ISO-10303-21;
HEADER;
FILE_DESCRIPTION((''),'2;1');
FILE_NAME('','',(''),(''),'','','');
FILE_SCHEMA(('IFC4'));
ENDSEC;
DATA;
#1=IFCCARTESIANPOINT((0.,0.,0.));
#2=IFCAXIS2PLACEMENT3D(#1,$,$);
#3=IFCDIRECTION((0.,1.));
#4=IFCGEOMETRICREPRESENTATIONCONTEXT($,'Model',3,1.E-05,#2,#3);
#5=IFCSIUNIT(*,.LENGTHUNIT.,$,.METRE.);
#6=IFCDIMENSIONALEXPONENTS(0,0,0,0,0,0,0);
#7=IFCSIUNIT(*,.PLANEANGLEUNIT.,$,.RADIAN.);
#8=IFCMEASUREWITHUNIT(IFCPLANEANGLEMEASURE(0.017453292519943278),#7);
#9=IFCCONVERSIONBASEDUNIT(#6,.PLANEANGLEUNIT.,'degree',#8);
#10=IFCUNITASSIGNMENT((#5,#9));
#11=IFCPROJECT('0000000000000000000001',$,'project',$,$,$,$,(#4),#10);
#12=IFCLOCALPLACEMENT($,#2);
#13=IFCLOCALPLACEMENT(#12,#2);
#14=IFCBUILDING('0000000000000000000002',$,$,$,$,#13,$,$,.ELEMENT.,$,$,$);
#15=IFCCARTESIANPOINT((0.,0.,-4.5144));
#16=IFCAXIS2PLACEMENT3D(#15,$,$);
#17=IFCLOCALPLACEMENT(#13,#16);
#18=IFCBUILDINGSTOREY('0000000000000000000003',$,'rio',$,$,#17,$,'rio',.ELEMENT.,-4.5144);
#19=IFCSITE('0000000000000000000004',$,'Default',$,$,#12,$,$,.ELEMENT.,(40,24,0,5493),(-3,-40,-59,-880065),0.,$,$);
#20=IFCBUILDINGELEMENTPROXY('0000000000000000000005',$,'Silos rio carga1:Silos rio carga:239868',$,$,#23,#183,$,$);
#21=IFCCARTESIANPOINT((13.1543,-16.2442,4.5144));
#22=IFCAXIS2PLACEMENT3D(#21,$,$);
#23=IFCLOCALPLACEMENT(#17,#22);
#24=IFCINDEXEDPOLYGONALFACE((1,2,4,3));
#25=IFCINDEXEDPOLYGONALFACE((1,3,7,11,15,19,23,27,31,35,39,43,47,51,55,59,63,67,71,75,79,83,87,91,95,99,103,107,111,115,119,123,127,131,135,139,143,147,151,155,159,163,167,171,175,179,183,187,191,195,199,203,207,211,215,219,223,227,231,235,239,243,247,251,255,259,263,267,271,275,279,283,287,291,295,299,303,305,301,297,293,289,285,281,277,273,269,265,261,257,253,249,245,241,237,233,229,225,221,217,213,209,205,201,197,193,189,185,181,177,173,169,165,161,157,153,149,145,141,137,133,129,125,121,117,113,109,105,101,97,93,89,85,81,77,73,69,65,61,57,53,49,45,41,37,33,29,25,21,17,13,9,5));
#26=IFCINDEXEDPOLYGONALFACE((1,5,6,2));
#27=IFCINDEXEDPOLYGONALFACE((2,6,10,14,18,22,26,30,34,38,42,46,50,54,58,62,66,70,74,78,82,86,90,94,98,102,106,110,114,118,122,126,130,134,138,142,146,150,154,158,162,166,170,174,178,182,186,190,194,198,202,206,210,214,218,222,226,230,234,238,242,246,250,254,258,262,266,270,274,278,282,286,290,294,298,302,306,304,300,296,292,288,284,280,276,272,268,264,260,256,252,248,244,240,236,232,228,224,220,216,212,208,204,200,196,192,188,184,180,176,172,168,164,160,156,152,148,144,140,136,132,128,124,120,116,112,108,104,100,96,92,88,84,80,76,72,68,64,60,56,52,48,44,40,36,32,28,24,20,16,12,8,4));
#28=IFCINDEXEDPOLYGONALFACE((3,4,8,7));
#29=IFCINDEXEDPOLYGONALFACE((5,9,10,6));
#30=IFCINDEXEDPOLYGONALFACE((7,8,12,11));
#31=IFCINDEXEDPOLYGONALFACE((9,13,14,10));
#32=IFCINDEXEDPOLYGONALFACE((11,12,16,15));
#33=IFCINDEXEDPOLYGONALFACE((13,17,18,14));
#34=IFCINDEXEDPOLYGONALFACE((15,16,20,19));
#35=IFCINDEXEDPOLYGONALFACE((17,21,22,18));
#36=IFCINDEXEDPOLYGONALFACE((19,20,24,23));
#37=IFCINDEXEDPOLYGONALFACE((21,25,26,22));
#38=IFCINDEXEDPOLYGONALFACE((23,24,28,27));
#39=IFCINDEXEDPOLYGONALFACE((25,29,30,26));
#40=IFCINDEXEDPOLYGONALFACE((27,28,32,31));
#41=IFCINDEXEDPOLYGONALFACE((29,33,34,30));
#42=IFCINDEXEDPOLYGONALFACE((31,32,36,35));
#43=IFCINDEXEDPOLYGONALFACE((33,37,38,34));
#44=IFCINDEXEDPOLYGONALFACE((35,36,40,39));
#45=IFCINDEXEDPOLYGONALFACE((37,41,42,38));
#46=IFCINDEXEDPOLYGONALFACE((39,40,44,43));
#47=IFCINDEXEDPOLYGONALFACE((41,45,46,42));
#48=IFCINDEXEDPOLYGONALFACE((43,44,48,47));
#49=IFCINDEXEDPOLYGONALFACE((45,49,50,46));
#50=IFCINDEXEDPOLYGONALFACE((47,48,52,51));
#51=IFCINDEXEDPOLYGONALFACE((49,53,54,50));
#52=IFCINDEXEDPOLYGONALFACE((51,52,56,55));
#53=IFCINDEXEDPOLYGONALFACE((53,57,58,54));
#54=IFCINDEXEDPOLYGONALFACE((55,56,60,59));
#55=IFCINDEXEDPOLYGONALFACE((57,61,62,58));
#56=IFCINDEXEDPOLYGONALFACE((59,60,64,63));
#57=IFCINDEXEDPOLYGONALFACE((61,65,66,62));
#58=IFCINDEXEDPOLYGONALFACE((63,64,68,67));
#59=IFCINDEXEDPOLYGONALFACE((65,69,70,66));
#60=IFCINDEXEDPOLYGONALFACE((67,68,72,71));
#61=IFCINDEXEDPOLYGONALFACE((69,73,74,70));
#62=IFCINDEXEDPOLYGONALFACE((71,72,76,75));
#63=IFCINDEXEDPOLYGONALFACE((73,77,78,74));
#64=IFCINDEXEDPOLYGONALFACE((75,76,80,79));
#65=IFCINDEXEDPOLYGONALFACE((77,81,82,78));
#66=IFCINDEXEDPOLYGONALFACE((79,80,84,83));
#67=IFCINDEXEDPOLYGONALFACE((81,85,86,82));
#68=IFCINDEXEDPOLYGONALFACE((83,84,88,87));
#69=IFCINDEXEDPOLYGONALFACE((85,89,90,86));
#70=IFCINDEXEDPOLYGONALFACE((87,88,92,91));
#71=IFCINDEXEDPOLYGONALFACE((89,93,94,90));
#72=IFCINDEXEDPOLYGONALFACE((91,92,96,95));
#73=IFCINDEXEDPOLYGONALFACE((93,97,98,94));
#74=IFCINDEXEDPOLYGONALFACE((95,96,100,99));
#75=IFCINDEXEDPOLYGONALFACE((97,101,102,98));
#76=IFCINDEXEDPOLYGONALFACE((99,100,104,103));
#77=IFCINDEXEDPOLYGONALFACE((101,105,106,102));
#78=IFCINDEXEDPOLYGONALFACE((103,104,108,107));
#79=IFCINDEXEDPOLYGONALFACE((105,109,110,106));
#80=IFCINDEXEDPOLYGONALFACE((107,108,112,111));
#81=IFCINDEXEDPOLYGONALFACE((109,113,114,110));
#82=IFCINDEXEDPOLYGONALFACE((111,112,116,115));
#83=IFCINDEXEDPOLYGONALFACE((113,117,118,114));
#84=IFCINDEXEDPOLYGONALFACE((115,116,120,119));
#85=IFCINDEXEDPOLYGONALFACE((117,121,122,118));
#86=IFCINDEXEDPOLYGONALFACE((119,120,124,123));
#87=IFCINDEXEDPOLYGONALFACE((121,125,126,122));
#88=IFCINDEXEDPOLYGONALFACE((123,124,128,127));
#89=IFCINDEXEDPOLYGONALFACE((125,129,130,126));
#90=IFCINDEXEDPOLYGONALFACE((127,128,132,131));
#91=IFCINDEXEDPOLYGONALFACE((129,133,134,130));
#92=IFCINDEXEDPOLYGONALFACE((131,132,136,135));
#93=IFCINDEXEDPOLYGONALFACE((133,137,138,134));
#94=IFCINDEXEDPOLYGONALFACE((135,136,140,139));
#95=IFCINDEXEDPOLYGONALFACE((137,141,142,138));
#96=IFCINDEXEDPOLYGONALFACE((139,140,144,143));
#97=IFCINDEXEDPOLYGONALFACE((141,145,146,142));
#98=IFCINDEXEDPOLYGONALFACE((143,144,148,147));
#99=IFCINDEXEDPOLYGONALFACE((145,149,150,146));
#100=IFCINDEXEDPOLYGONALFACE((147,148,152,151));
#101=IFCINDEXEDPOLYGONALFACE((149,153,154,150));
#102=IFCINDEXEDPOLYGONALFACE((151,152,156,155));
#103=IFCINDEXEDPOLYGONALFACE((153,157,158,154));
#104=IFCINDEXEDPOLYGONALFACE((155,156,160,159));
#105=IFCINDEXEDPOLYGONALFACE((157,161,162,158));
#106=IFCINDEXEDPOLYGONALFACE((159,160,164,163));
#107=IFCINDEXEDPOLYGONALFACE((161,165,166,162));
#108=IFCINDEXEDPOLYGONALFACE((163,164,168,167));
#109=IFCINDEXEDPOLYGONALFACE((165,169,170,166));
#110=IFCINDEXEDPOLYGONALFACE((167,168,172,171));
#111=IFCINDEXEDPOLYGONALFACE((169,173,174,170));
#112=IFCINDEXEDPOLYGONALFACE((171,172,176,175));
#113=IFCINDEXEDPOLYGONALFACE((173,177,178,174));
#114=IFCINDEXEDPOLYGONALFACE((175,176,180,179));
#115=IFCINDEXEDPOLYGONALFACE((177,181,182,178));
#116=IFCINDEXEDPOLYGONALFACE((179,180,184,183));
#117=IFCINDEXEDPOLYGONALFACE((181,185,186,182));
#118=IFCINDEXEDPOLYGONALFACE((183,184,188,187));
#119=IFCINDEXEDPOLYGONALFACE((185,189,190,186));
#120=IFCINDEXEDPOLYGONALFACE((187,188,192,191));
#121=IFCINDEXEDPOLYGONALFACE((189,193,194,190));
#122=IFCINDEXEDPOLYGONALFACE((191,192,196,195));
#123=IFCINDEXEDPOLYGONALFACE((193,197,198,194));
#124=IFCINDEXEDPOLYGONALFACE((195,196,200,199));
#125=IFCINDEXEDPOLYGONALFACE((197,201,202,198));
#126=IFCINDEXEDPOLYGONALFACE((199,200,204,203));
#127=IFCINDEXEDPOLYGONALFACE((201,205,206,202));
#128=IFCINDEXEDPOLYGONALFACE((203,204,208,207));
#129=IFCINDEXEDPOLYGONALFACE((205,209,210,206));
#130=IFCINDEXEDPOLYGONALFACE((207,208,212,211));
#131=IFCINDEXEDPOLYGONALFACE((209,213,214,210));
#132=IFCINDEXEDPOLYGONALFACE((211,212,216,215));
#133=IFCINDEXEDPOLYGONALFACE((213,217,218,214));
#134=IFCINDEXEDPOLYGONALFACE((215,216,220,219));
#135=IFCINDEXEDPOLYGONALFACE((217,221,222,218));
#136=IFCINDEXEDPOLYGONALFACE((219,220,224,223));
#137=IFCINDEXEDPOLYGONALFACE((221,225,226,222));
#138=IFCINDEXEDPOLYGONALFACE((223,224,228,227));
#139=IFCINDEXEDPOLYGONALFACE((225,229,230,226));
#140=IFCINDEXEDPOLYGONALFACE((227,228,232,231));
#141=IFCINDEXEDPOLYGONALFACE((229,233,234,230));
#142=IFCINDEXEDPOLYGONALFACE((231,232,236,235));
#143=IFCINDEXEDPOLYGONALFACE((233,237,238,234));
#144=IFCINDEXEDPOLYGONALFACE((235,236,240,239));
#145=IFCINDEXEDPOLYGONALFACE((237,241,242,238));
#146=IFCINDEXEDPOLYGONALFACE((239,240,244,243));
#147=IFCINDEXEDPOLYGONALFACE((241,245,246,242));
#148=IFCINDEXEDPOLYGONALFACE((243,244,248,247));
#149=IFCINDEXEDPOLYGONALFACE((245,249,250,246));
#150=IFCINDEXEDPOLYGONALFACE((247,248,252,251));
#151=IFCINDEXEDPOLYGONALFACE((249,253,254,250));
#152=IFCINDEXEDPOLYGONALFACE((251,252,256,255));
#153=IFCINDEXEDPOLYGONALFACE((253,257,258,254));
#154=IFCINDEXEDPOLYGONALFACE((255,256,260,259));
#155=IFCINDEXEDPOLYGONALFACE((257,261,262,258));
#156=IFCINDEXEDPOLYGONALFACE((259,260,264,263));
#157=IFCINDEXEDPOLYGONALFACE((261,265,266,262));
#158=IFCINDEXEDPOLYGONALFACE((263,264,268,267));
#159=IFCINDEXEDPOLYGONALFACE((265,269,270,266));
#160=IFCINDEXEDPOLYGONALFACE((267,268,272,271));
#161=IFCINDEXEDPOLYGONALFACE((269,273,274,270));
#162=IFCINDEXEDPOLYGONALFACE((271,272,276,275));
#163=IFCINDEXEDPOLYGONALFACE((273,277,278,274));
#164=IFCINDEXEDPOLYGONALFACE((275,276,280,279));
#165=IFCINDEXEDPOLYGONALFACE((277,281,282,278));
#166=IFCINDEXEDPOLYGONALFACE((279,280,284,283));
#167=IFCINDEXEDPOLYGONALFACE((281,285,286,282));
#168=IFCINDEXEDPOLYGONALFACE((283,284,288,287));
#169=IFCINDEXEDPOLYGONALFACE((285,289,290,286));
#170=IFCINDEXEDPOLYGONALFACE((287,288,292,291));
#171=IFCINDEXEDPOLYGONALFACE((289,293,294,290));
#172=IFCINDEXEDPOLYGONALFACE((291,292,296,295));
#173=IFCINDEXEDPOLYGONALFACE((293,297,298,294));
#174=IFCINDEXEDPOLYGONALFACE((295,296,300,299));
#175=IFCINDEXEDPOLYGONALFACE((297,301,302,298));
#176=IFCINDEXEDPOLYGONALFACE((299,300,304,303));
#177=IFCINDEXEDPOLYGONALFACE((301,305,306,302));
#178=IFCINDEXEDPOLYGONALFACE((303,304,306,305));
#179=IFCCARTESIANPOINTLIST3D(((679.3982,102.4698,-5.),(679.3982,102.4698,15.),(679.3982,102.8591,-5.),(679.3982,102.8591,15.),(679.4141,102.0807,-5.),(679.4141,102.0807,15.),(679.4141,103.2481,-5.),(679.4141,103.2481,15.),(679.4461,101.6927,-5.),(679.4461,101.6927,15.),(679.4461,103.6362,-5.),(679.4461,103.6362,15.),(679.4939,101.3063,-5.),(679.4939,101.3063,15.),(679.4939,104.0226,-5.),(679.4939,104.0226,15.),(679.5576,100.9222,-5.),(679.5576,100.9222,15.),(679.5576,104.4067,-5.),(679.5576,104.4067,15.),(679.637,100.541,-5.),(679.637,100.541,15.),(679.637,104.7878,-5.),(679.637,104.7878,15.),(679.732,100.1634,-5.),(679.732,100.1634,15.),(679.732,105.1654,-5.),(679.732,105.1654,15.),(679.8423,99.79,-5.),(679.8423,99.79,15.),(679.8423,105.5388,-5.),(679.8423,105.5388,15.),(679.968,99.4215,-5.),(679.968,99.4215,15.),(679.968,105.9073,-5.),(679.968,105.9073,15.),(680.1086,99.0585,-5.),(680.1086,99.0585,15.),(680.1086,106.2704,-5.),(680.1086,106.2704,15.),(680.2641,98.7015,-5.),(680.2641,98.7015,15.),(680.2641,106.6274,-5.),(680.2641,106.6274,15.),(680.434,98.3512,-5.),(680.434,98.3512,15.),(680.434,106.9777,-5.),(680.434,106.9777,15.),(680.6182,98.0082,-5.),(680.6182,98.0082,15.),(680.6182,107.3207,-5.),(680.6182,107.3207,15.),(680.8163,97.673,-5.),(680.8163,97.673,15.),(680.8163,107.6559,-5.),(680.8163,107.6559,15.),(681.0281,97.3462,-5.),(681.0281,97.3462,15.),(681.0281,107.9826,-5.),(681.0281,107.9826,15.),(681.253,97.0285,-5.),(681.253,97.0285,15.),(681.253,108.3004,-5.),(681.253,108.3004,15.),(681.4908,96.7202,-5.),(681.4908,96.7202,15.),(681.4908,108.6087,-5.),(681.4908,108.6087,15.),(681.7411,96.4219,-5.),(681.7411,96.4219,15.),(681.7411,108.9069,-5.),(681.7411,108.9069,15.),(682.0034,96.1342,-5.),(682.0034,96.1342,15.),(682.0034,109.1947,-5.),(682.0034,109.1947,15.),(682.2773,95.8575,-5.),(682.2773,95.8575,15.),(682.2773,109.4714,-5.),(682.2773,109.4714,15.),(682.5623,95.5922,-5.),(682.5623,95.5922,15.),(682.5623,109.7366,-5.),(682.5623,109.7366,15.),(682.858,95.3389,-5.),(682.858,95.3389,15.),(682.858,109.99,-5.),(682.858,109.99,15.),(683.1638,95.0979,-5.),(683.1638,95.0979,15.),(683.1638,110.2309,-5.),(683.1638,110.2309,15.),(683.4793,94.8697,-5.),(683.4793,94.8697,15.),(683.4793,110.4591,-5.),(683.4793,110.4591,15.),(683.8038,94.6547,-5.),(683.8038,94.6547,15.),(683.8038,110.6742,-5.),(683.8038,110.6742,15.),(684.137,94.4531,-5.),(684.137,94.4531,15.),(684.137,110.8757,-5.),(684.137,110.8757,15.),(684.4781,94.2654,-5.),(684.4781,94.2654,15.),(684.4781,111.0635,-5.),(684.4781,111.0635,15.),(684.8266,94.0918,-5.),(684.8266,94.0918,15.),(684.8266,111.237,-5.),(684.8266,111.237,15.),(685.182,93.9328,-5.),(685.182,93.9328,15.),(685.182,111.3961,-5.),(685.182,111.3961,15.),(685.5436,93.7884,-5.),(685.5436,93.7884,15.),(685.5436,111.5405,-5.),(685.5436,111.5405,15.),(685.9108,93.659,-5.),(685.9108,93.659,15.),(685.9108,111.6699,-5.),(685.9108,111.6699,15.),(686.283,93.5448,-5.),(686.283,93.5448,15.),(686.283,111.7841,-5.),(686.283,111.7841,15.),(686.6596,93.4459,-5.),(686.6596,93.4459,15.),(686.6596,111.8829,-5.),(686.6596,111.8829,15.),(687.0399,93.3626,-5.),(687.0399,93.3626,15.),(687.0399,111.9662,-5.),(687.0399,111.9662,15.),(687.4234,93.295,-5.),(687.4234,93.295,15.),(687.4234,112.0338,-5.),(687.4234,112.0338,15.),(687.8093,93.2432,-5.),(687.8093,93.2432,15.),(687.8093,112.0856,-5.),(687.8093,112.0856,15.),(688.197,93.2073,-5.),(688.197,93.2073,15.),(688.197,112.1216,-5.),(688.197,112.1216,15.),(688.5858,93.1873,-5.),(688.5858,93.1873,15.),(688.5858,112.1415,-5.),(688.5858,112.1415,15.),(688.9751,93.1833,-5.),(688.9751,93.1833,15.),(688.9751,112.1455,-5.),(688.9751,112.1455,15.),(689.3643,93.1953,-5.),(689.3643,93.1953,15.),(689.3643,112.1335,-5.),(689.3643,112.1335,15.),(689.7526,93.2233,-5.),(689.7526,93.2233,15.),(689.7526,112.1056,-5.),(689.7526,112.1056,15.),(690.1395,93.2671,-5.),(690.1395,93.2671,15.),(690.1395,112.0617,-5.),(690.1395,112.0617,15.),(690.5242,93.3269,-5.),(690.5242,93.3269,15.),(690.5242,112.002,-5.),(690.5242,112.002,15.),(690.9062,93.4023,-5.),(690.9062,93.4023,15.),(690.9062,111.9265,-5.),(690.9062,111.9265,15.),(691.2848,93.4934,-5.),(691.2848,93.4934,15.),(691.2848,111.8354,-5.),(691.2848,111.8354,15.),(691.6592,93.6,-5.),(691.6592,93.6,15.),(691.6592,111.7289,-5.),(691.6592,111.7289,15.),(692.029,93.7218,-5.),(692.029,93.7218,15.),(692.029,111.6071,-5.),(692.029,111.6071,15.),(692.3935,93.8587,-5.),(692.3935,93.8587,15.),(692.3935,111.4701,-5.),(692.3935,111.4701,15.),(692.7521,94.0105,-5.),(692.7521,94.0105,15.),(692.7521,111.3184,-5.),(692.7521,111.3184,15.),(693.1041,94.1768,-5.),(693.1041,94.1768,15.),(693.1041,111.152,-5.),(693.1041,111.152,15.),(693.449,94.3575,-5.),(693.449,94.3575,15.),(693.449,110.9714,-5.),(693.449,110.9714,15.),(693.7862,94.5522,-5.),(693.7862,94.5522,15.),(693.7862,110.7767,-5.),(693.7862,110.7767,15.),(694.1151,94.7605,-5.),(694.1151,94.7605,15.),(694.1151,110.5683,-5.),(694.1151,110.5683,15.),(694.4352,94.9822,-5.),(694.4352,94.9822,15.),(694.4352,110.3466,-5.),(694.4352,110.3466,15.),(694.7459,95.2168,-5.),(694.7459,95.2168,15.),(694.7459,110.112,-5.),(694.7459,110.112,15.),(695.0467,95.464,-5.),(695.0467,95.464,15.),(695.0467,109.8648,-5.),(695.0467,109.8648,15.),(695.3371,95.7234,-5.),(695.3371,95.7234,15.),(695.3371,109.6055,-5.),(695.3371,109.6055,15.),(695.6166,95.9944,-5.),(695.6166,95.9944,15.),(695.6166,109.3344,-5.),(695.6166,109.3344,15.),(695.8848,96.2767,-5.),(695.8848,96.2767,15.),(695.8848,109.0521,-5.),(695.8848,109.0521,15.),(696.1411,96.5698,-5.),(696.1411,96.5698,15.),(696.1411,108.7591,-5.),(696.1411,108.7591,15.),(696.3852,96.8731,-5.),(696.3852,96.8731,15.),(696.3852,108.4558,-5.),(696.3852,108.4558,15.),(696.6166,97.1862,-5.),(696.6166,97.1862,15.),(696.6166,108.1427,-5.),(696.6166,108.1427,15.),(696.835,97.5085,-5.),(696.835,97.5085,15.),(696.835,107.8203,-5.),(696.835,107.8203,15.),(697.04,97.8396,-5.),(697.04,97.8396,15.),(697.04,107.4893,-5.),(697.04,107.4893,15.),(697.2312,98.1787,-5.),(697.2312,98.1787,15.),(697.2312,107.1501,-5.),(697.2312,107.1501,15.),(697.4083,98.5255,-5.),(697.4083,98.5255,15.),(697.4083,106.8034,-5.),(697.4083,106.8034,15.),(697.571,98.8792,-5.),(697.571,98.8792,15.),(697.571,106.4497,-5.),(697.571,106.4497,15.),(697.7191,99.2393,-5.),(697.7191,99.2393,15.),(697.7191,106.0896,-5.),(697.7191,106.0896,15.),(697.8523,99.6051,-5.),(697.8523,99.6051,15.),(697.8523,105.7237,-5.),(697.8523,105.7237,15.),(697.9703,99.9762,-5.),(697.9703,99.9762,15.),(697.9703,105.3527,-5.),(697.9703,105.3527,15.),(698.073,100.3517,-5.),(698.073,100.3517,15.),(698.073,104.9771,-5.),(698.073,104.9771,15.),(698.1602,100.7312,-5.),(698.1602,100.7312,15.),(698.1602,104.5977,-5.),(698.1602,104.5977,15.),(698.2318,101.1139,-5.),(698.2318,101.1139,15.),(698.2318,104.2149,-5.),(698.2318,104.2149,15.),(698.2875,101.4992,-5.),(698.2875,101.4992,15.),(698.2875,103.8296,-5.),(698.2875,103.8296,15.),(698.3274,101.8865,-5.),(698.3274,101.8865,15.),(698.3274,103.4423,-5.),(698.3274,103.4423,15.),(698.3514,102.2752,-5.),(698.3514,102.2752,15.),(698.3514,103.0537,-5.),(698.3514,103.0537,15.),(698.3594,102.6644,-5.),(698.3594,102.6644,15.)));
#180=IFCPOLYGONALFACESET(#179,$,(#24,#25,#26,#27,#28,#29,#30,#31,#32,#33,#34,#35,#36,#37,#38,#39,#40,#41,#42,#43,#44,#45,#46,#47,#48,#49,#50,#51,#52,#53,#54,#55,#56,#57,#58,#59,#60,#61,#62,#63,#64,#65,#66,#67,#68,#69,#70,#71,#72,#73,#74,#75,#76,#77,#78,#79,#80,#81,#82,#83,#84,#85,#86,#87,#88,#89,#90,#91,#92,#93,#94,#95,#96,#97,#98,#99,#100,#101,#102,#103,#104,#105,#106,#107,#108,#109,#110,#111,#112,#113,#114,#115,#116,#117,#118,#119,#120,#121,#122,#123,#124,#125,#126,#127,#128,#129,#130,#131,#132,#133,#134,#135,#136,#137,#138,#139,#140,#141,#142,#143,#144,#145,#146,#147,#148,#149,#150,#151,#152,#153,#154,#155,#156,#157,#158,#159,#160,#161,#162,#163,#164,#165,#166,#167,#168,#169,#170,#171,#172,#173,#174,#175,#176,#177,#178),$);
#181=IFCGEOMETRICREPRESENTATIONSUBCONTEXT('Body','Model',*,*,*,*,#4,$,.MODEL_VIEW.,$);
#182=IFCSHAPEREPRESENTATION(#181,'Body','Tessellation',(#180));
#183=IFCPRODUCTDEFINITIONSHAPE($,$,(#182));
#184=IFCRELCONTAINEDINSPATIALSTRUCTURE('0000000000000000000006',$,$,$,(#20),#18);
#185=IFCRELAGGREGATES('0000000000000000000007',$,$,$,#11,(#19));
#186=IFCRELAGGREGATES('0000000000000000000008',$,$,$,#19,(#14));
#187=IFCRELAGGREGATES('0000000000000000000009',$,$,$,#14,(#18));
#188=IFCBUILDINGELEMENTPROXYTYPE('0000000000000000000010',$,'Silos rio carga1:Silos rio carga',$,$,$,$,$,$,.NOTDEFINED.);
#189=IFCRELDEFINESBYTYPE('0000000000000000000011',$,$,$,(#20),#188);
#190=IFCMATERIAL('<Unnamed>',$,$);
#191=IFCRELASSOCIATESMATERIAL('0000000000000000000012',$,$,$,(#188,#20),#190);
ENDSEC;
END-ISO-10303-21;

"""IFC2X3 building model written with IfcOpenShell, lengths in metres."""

from ifc_helpers import new_model, entity, si_unit, converted_unit, direction, frame, frame_2d, origin, place, context, subcontext, project, spatial, circle, extrude, source, transform, mapped, material, type_object, type_shapes, element, save


model = new_model("IFC2X3")

# Units and contexts
model_context = context("Model", 3, precision=1e-05, world=origin(), true_north=direction((0.0, 1.0)))
body_context = subcontext(model_context, "Body", "Model", "MODEL_VIEW")
ifc_project = project(units=[si_unit("LENGTHUNIT", "METRE"), converted_unit("PLANEANGLEUNIT", "degree", entity("IfcPlaneAngleMeasure", 0.017453292519943278), si_unit("PLANEANGLEUNIT", "RADIAN"), dimensions=[0, 0, 0, 0, 0, 0, 0])], contexts=[model_context])

# Site, building, storey
site_placement = place(None, origin())
site = spatial("IfcSite", under=ifc_project, at=site_placement, Name="Default", CompositionType="ELEMENT", RefLatitude=(40, 24, 0, 5493), RefLongitude=(-3, -40, -59, -880065), RefElevation=0.0)
building_placement = place(site_placement, origin())
building = spatial("IfcBuilding", under=site, at=building_placement, CompositionType="ELEMENT")
storey_placement = place(building_placement, frame((0.0, 0.0, -4.5144)))
storey = spatial("IfcBuildingStorey", under=building, at=storey_placement, Name="rio", LongName="rio", CompositionType="ELEMENT", Elevation=-4.5144)

# Building element proxy
ifc_material_1 = material(Name="<Unnamed>")
building_element_proxy_type_1 = type_object("IfcBuildingElementProxyType", Name="Silos rio carga1:Silos rio carga", PredefinedType="NOTDEFINED", material=ifc_material_1)
shared_shape_1 = source(origin(), body_context, "Body", "SweptSolid", [
    extrude(circle(Radius=9.4816, at=frame_2d((0.0, 0.0), x_axis=(1.0, 0.0))), frame((688.8778, 102.6644, -5.0)), (0.0, 0.0, 1.0), 20.0),
])
type_shapes(building_element_proxy_type_1, [shared_shape_1])
proxy_1_placement = place(storey_placement, frame((13.1543, -16.2442, 4.5144)))
element("IfcBuildingElementProxy", 1, at=proxy_1_placement, inside=storey, type_object=building_element_proxy_type_1, material=ifc_material_1, Name="Silos rio carga1:Silos rio carga:239868", context=body_context, shape_type="MappedRepresentation", body=[
    mapped(shared_shape_1, transform((0.0, 0.0, 0.0), scale=1.0)),
])

save(model, "model.ifc")
